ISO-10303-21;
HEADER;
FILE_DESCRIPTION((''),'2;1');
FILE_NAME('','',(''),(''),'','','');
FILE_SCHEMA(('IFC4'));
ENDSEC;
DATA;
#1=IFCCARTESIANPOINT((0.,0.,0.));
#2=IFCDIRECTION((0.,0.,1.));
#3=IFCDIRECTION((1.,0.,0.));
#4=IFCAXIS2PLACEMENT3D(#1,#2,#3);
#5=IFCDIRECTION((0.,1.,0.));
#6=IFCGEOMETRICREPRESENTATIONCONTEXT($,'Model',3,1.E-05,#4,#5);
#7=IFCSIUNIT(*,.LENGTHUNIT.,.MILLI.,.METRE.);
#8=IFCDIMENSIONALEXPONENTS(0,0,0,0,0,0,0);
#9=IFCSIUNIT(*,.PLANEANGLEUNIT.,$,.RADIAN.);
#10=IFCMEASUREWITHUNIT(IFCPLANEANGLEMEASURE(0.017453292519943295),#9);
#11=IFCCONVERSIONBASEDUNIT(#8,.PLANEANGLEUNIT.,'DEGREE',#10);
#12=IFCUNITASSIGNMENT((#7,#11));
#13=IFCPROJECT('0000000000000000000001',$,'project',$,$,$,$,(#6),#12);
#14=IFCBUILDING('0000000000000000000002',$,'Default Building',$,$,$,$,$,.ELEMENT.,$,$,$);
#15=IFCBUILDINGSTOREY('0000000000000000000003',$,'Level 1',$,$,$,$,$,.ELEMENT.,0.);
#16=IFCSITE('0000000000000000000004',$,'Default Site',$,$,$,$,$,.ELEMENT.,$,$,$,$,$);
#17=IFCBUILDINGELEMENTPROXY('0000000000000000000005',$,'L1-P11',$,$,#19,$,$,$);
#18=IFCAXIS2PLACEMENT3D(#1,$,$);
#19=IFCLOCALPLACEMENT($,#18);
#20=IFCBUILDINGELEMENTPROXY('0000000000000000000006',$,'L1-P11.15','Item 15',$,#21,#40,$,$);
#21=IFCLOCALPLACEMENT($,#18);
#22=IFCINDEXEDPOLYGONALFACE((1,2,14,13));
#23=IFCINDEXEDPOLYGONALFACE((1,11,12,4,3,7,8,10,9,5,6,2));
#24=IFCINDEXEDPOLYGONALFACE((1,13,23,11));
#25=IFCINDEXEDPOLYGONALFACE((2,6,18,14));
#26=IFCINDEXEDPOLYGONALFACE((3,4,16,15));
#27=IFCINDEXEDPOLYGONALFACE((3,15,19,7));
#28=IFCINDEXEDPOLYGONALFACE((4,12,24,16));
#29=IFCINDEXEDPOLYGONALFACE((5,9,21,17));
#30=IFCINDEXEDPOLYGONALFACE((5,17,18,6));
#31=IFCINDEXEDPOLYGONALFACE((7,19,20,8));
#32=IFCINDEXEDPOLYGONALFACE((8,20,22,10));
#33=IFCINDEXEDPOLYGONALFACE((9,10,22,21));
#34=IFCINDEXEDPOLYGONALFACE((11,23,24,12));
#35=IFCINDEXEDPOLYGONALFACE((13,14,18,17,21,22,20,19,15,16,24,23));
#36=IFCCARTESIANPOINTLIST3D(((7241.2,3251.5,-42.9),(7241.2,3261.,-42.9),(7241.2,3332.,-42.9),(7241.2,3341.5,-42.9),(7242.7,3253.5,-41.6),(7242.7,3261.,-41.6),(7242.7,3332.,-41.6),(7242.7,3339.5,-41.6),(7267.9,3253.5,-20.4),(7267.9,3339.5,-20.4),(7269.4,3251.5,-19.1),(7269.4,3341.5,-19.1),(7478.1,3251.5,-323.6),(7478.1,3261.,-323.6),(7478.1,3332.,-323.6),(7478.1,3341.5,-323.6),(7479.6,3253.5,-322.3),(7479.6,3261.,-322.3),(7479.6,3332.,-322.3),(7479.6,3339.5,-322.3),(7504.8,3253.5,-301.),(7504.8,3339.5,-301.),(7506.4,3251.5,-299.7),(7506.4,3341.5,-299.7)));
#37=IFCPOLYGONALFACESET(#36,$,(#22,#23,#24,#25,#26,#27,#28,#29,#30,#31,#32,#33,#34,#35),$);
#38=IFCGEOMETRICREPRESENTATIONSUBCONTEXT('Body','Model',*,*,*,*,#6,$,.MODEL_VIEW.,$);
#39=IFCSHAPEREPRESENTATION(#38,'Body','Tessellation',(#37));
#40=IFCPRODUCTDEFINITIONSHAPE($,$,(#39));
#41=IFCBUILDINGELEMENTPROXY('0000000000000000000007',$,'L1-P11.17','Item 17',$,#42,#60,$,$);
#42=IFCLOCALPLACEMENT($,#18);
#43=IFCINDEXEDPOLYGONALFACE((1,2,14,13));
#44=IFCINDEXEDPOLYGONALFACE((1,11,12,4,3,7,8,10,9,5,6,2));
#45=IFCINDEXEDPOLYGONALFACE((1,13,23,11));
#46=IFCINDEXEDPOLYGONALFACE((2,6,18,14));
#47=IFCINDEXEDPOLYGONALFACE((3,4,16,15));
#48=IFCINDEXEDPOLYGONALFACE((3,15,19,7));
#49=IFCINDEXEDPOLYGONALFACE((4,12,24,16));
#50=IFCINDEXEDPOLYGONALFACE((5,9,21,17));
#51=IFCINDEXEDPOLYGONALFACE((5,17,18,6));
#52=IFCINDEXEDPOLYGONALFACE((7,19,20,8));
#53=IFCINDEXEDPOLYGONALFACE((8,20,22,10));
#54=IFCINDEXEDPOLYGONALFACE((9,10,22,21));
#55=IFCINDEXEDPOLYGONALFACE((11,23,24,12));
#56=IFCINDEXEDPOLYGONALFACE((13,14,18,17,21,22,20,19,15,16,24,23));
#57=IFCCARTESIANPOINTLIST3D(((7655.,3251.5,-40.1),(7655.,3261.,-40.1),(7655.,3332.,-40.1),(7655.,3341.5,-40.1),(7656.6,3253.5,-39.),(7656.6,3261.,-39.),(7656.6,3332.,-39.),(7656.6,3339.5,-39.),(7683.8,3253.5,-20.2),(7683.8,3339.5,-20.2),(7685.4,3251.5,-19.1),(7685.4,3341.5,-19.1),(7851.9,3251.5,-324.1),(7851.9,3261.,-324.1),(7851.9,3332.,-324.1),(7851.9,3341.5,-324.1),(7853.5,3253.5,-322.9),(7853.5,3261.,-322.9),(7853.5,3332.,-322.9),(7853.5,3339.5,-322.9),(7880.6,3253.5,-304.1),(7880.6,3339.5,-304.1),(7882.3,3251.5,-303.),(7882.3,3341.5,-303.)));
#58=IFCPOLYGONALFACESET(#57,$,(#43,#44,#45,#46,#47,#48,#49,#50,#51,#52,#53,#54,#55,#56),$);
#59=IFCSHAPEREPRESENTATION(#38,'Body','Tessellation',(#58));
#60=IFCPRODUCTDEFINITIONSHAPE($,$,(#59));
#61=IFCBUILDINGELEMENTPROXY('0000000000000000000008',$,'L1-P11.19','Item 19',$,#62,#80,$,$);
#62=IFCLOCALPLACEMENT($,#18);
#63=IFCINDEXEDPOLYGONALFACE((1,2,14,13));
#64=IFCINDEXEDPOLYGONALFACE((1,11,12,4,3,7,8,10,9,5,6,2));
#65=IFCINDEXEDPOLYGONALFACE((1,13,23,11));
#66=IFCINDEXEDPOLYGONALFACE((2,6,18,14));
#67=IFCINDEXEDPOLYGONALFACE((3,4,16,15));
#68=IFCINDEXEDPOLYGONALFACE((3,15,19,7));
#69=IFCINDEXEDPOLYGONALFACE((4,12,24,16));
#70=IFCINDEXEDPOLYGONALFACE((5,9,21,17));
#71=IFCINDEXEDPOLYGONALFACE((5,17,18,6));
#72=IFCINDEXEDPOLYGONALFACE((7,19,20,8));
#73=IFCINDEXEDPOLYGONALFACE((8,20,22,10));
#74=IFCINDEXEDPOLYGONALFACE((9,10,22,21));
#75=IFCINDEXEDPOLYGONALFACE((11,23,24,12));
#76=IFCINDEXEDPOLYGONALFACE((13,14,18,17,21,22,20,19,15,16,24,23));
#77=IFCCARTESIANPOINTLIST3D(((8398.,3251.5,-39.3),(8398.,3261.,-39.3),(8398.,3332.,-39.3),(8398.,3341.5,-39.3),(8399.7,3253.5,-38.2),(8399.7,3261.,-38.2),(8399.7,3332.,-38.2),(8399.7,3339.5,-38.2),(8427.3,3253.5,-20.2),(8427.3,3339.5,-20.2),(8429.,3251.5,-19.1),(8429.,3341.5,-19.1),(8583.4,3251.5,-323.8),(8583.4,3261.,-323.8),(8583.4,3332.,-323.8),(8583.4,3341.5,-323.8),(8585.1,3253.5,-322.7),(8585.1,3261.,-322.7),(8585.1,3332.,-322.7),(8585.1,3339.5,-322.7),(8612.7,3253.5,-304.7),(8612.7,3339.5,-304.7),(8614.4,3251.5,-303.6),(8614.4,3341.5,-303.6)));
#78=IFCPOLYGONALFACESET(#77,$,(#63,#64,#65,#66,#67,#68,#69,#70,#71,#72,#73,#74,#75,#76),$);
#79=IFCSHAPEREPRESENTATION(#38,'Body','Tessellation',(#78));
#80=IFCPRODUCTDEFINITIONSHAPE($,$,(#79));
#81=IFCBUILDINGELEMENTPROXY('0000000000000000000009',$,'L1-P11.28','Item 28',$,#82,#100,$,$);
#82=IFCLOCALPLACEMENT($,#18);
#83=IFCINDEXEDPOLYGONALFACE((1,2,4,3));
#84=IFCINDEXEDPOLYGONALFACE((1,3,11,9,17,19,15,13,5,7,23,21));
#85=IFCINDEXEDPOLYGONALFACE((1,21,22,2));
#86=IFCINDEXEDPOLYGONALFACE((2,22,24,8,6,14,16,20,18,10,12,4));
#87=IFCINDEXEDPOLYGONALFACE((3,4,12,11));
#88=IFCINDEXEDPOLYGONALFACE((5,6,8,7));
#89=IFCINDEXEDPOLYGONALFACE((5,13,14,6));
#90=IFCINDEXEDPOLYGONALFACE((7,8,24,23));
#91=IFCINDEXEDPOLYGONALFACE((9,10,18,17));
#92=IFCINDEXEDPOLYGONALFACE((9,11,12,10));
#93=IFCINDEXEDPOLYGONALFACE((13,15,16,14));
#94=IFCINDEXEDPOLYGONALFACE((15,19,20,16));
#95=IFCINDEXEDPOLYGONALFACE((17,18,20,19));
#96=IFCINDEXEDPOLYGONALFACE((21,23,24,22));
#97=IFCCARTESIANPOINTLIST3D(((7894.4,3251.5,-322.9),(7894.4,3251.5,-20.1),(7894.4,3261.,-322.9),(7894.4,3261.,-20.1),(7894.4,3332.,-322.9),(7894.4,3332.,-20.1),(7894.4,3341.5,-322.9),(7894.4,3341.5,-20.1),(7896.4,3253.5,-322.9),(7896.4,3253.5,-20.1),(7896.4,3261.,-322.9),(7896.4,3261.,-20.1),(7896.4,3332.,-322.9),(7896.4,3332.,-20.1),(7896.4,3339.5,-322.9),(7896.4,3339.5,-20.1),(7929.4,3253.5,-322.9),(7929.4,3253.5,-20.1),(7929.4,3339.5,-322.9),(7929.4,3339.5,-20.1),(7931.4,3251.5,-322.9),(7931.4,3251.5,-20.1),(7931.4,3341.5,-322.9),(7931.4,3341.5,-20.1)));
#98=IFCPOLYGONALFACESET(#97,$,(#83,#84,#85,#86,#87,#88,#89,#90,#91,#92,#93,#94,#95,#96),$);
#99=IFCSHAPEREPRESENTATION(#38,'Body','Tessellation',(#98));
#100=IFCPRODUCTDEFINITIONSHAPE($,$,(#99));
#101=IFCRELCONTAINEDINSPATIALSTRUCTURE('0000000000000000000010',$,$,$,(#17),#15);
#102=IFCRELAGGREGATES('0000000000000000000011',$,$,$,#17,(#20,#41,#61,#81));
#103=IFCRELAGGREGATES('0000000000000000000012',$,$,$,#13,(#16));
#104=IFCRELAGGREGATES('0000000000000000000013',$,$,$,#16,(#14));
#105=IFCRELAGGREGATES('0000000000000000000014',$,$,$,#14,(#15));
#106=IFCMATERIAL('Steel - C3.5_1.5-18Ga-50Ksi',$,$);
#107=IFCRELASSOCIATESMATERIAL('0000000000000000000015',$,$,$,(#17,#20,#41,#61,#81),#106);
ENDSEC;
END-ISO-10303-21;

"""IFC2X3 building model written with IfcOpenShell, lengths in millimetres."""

from ifc_helpers import new_model, entity, si_unit, converted_unit, direction, frame, origin, origin_with_axes, origin_2d_with_axis, place, context, subcontext, project, spatial, c_section, extrude, material, element, aggregate, save


model = new_model("IFC2X3")

# Units and contexts
model_context = context("Model", 3, precision=1e-05, world=origin_with_axes(), true_north=direction((0.0, 1.0, 0.0)))
body_context = subcontext(model_context, "Body", "Model", "MODEL_VIEW")
ifc_project = project(units=[si_unit("LENGTHUNIT", "METRE", prefix="MILLI"), converted_unit("PLANEANGLEUNIT", "DEGREE", entity("IfcPlaneAngleMeasure", 0.017453292519943295), si_unit("PLANEANGLEUNIT", "RADIAN"), dimensions=[0, 0, 0, 0, 0, 0, 0])], contexts=[model_context])

# Site, building, storey
site = spatial("IfcSite", under=ifc_project, Name="Default Site", CompositionType="ELEMENT")
building = spatial("IfcBuilding", under=site, Name="Default Building", CompositionType="ELEMENT")
storey = spatial("IfcBuildingStorey", under=building, Name="Level 1", CompositionType="ELEMENT", Elevation=0.0)

# Building element proxies
ifc_material_1 = material(Name="Steel - C3.5_1.5-18Ga-50Ksi")
proxy_1 = element("IfcBuildingElementProxy", 1, inside=storey, material=ifc_material_1, Name="L1-P11")
proxy_2_placement = place(None, frame((7255.3, 3296.5, -31.0), z_axis=(0.645, 0.0, -0.764), x_axis=(-28.284, 0.0, -23.854)))
proxy_2 = element("IfcBuildingElementProxy", 2, at=proxy_2_placement, material=ifc_material_1, Name="L1-P11.15", Description="Item 15", context=body_context, shape_type="SweptSolid", body=[
    extrude(c_section(Depth=90.0, Width=37.0, WallThickness=2.0, Girth=9.5, at=origin_2d_with_axis()), origin(), (0.0, 0.0, 1.0), 367.3),
])
proxy_3_placement = place(None, frame((7670.2, 3296.5, -29.6), z_axis=(0.57, 0.0, -0.822), x_axis=(-30.402, 0.0, -21.088)))
proxy_3 = element("IfcBuildingElementProxy", 3, at=proxy_3_placement, material=ifc_material_1, Name="L1-P11.17", Description="Item 17", context=body_context, shape_type="SweptSolid", body=[
    extrude(c_section(Depth=90.0, Width=37.0, WallThickness=2.0, Girth=9.5, at=origin_2d_with_axis()), origin(), (0.0, 0.0, 1.0), 345.5),
])
proxy_4_placement = place(None, frame((8413.5, 3296.5, -29.2), z_axis=(0.546, 0.0, -0.838), x_axis=(-30.996, 0.0, -20.206)))
proxy_4 = element("IfcBuildingElementProxy", 4, at=proxy_4_placement, material=ifc_material_1, Name="L1-P11.19", Description="Item 19", context=body_context, shape_type="SweptSolid", body=[
    extrude(c_section(Depth=90.0, Width=37.0, WallThickness=2.0, Girth=9.5, at=origin_2d_with_axis()), origin(), (0.0, 0.0, 1.0), 339.6),
])
proxy_5_placement = place(None, frame((7912.9, 3296.5, -20.1), z_axis=(0.0, 0.0, -1.0), x_axis=(-37.0, 0.0, 0.0)))
proxy_5 = element("IfcBuildingElementProxy", 5, at=proxy_5_placement, material=ifc_material_1, Name="L1-P11.28", Description="Item 28", context=body_context, shape_type="SweptSolid", body=[
    extrude(c_section(Depth=90.0, Width=37.0, WallThickness=2.0, Girth=9.5, at=origin_2d_with_axis()), origin(), (0.0, 0.0, 1.0), 302.8),
])
aggregate(proxy_1, [proxy_2, proxy_3, proxy_4, proxy_5])

save(model, "model.ifc")
